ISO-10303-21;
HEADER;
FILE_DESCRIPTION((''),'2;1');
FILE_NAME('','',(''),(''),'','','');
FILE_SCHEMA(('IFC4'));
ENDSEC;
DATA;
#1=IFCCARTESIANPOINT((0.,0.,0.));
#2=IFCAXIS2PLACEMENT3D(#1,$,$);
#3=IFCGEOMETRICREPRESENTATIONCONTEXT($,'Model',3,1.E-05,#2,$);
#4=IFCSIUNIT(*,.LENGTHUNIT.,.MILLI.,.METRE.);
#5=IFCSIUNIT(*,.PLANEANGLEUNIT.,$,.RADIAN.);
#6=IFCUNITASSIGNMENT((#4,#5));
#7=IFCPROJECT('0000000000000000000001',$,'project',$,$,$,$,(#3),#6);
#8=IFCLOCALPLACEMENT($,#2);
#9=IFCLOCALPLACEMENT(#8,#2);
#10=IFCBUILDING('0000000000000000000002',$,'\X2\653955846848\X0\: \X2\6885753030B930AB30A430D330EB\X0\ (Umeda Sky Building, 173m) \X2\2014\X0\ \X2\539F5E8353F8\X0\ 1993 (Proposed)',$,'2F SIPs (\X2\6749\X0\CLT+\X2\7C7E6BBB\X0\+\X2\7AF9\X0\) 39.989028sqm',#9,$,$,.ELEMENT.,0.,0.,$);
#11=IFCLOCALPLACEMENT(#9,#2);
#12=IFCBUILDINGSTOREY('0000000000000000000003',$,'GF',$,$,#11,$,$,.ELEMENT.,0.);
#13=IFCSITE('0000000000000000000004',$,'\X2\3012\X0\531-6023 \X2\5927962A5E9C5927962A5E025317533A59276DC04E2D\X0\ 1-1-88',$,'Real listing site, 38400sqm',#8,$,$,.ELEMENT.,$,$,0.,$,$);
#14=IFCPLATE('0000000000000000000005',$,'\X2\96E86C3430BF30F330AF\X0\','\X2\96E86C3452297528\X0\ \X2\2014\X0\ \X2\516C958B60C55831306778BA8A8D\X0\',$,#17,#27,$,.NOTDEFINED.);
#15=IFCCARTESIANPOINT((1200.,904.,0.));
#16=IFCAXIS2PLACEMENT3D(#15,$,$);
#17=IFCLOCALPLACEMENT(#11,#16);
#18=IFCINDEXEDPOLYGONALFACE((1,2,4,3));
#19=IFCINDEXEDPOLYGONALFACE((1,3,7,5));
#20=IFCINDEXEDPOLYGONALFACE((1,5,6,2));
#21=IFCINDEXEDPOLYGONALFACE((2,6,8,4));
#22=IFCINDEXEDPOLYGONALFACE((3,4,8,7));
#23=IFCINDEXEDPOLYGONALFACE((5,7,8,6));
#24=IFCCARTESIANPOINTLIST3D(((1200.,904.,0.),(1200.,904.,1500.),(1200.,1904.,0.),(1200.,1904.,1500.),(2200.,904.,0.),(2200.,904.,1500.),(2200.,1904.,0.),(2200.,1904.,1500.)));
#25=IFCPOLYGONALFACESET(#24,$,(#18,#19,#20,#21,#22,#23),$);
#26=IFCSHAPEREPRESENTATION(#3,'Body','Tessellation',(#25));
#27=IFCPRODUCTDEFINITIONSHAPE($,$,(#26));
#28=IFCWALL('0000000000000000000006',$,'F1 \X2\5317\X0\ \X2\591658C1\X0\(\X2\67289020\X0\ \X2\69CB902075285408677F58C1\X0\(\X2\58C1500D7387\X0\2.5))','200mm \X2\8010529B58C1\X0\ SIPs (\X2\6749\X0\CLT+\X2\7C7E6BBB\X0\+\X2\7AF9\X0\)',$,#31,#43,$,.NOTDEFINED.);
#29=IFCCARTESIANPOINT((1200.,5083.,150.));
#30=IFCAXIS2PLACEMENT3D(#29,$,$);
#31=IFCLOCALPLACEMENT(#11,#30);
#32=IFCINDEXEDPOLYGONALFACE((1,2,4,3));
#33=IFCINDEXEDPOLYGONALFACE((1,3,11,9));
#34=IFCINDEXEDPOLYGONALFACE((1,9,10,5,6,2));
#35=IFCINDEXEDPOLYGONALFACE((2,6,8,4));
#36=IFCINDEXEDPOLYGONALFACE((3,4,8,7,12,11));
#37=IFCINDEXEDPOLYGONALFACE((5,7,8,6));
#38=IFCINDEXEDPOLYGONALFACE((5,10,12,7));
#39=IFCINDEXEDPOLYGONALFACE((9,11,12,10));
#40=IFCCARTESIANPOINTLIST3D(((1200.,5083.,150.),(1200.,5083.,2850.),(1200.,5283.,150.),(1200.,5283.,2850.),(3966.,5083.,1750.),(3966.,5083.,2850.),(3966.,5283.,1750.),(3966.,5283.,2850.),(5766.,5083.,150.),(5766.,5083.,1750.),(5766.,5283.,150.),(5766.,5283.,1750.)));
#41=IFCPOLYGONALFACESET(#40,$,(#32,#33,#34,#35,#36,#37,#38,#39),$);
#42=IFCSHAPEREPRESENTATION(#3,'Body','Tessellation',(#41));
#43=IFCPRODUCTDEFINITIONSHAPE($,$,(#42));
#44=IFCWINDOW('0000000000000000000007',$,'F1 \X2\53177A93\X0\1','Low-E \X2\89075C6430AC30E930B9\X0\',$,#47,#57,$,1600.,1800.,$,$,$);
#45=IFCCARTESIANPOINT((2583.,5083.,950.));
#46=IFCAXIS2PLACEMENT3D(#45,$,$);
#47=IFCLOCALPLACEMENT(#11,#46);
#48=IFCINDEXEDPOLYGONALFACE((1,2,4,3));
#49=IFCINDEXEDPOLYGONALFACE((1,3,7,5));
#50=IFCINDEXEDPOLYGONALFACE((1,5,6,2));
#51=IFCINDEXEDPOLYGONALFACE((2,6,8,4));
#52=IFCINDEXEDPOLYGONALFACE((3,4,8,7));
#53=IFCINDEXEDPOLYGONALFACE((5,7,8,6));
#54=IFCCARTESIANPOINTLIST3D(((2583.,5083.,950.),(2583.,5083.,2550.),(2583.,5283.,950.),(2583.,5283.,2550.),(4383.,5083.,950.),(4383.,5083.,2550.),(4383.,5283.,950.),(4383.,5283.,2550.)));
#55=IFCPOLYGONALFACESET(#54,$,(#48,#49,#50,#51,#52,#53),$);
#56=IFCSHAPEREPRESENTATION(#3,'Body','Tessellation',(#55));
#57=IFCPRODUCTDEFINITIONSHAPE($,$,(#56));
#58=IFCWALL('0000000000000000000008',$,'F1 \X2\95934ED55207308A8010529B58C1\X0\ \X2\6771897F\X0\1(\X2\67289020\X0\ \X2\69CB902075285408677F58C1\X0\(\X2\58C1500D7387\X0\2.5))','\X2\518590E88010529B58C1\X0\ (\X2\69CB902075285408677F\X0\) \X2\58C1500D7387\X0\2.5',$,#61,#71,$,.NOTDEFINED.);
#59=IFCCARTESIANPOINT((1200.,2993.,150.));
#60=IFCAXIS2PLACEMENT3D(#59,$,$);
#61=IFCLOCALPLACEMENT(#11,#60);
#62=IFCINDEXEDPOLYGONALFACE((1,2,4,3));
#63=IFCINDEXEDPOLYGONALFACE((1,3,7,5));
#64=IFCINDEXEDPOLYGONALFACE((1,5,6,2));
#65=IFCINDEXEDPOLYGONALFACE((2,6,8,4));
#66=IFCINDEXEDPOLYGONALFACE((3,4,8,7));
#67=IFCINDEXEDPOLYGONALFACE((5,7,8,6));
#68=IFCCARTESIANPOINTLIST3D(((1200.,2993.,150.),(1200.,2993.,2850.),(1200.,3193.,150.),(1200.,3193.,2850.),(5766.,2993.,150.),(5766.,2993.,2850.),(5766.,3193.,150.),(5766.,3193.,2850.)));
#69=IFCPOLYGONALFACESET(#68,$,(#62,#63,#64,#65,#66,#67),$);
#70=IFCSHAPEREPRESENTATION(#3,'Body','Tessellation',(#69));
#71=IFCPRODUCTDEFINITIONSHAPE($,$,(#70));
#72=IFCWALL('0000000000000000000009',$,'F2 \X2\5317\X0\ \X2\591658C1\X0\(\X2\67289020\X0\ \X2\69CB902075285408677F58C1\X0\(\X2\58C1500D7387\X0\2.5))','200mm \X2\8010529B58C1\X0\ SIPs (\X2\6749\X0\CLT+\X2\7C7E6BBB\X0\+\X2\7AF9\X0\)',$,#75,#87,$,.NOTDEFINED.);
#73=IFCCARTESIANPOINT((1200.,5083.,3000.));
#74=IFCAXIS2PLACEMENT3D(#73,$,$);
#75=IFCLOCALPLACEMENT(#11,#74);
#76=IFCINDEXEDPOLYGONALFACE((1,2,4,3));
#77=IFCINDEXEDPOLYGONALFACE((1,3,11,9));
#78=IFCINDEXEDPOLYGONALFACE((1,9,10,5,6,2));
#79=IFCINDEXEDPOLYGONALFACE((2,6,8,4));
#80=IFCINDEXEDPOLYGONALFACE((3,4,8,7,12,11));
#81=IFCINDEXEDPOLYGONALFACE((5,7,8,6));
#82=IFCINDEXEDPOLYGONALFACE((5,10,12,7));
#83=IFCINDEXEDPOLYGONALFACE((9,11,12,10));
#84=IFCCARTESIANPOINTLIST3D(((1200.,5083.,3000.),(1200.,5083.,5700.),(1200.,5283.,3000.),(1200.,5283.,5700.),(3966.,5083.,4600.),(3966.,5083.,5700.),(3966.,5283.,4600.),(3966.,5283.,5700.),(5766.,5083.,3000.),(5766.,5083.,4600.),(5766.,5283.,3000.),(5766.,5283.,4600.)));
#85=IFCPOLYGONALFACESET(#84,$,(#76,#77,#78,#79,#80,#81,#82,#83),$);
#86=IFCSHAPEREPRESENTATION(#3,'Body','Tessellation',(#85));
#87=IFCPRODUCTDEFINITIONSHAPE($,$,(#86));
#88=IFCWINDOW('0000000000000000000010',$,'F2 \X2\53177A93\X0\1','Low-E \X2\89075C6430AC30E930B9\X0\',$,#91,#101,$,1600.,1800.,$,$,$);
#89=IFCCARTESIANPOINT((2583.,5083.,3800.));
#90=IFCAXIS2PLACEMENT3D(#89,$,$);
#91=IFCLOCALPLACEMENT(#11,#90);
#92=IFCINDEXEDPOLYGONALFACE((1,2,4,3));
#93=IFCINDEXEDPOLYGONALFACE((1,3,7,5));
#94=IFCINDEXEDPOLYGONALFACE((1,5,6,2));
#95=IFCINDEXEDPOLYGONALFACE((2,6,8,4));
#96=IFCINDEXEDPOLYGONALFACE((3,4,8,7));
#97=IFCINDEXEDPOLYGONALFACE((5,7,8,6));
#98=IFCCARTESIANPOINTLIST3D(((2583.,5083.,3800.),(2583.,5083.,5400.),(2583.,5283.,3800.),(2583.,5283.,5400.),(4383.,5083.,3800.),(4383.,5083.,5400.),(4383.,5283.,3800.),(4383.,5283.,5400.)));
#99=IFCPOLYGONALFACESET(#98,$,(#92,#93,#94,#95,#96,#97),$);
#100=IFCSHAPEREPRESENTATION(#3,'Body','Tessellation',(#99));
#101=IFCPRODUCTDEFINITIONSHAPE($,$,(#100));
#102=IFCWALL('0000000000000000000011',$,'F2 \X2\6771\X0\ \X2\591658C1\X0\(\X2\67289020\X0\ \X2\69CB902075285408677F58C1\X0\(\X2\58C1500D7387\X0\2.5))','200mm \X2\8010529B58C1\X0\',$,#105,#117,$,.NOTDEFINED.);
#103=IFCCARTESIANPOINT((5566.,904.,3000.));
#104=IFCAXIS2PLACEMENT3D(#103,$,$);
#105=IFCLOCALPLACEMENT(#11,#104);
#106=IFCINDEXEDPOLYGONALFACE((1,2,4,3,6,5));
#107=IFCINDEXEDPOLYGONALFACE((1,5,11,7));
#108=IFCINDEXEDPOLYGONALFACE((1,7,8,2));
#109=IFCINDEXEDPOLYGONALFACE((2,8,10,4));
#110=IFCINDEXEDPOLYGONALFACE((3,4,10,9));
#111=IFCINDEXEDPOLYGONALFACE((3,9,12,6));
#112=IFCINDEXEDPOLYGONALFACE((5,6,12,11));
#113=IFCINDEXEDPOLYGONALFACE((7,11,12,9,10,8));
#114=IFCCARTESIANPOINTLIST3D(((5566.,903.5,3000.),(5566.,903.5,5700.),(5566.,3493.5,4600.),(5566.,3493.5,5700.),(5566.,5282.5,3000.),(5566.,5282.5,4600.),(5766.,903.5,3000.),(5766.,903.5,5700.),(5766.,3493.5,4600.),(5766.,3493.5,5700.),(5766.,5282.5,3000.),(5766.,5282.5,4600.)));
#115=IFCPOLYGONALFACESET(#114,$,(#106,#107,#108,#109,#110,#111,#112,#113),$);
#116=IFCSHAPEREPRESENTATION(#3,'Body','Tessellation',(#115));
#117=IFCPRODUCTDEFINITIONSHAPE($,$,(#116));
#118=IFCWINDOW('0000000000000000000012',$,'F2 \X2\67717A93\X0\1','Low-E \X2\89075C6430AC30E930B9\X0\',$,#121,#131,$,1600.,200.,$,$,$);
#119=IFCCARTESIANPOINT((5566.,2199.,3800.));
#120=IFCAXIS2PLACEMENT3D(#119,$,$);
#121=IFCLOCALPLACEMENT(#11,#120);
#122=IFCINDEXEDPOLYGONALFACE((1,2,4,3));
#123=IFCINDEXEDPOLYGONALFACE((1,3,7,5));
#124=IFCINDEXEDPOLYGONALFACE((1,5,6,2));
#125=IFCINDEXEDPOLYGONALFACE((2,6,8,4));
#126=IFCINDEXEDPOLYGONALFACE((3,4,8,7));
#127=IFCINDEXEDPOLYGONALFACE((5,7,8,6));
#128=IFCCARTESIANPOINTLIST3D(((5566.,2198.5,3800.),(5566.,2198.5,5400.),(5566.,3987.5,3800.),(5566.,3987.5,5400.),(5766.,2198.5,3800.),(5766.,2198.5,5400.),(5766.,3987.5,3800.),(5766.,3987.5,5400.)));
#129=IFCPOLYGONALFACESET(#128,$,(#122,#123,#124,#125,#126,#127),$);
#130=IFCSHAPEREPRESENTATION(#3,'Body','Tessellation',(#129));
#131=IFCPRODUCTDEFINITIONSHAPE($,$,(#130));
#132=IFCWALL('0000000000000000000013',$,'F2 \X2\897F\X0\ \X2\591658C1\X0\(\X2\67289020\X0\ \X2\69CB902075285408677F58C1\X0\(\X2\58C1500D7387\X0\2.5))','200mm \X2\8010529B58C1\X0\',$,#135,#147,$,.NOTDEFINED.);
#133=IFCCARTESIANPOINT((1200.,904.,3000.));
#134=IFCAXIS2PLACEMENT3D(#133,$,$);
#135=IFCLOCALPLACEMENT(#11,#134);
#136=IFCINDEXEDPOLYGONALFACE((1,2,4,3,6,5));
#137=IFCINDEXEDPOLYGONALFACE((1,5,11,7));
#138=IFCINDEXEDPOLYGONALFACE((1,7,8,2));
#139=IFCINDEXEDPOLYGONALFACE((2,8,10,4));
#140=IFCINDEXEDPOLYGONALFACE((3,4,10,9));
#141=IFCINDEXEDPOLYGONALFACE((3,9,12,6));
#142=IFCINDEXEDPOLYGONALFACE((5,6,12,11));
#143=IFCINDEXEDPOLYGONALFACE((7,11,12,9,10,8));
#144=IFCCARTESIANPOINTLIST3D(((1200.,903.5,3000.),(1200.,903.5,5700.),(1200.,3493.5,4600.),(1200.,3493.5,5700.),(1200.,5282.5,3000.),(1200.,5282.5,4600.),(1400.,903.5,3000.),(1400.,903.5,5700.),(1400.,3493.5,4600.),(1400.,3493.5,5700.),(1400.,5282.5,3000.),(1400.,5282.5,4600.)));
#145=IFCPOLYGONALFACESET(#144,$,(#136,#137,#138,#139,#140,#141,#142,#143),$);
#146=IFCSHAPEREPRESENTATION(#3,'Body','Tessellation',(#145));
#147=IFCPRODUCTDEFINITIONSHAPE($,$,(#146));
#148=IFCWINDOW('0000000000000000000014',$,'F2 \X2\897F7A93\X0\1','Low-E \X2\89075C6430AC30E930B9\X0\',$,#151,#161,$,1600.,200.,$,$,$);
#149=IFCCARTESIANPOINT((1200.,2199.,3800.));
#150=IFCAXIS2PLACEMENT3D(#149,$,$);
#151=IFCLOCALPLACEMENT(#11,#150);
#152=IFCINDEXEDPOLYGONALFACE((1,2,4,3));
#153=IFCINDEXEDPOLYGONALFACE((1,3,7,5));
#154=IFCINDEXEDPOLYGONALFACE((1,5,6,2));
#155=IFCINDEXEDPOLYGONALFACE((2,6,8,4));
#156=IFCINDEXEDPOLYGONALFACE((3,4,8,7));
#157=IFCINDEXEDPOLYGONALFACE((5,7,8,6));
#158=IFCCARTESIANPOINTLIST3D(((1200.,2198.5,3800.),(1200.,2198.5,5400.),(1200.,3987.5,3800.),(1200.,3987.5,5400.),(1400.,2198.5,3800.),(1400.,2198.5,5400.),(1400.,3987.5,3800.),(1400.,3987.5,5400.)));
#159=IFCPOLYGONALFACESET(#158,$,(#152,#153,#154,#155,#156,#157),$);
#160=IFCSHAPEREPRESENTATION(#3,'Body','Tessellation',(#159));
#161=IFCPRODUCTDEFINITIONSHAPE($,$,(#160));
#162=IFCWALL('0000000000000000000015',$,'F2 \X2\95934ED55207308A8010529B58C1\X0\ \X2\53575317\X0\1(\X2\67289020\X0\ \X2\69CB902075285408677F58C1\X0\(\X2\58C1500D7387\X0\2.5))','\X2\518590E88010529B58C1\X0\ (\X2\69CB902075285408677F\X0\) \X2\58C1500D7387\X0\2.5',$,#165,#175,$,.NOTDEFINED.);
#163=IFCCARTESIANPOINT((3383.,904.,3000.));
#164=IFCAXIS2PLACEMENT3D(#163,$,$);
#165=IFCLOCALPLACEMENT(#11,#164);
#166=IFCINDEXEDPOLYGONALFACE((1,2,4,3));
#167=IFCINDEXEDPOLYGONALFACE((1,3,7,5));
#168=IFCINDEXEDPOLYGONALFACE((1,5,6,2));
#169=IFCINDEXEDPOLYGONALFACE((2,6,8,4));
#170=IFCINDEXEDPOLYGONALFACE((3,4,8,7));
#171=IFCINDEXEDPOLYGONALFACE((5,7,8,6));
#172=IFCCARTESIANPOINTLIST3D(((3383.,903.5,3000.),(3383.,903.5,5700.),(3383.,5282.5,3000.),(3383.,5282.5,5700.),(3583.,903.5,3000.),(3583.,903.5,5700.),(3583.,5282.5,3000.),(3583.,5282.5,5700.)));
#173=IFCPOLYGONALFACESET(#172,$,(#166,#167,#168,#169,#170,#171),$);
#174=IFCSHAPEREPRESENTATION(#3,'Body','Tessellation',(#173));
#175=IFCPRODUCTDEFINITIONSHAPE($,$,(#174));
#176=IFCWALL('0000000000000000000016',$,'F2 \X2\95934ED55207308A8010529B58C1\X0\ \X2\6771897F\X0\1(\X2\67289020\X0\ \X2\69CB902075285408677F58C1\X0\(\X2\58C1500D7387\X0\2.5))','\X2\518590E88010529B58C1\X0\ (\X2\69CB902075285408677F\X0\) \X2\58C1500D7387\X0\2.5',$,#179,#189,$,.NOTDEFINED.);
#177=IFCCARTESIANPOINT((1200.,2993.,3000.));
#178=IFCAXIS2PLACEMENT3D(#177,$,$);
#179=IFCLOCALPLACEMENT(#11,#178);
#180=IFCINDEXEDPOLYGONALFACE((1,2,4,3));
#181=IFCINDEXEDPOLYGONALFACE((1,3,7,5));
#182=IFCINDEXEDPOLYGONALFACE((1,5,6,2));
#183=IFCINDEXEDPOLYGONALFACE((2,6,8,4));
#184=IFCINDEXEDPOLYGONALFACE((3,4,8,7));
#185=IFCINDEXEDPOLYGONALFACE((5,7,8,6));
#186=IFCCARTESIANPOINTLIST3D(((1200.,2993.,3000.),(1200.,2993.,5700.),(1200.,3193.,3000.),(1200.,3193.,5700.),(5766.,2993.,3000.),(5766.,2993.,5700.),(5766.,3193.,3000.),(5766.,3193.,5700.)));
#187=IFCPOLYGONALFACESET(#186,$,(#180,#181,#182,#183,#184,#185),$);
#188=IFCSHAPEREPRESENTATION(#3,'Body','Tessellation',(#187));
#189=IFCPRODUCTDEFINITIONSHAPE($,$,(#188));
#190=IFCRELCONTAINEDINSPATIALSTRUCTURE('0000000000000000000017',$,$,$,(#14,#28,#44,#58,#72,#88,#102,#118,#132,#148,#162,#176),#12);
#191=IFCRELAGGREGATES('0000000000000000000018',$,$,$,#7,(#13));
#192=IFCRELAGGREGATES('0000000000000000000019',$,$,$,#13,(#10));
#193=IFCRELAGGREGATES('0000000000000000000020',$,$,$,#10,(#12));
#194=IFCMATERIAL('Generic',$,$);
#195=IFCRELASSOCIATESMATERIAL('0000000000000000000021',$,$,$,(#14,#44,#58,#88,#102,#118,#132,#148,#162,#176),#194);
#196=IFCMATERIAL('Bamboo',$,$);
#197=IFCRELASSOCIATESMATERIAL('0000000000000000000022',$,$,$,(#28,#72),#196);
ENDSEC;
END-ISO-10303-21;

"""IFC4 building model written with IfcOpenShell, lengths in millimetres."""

from ifc_helpers import new_model, si_unit, frame, frame_2d, origin, place, context, project, spatial, rectangle, extrude, material, element, fill, save


model = new_model("IFC4")

# Units and contexts
model_context = context("Model", 3, precision=1e-05, world=origin())
ifc_project = project(units=[si_unit("LENGTHUNIT", "METRE", prefix="MILLI"), si_unit("PLANEANGLEUNIT", "RADIAN")], contexts=[model_context])

# Site, building, storey
site_placement = place(None, origin())
site = spatial("IfcSite", under=ifc_project, at=site_placement, Name="〒531-6023 大阪府大阪市北区大淀中 1-1-88", ObjectType="Real listing site, 38400sqm", CompositionType="ELEMENT", RefElevation=0.0)
building_placement = place(site_placement, origin())
building = spatial("IfcBuilding", under=site, at=building_placement, Name="改善案: 梅田スカイビル (Umeda Sky Building, 173m) — 原広司 1993 (Proposed)", ObjectType="2F SIPs (杉CLT+籾殻+竹) 39.989028sqm", CompositionType="ELEMENT", ElevationOfRefHeight=0.0, ElevationOfTerrain=0.0)
storey_placement = place(building_placement, origin())
storey = spatial("IfcBuildingStorey", under=building, at=storey_placement, Name="GF", CompositionType="ELEMENT", Elevation=0.0)

# Plate
ifc_material_1 = material(Name="Generic")
plate_placement = place(storey_placement, frame((1200.0, 904.0, 0.0)))
element("IfcPlate", 1, at=plate_placement, inside=storey, material=ifc_material_1, Name="雨水タンク", Description="雨水利用 — 公開情報で確認", PredefinedType="NOTDEFINED", context=model_context, shape_type="SweptSolid", body=[
    extrude(rectangle(XDim=1000.0, YDim=1000.0, at=frame_2d((500.0, 500.0))), frame((1200.0, 904.0, 0.0)), (0.0, 0.0, 1.0), 1500.0),
])

# Wall, opening, window
ifc_material_2 = material(Name="Bamboo")
wall_1_placement = place(storey_placement, frame((1200.0, 5083.0, 150.0)))
wall_1 = element("IfcWall", 2, at=wall_1_placement, inside=storey, material=ifc_material_2, Name="F1 北 外壁(木造 構造用合板壁(壁倍率2.5))", Description="200mm 耐力壁 SIPs (杉CLT+籾殻+竹)", PredefinedType="NOTDEFINED", context=model_context, shape_type="SweptSolid", body=[
    extrude(rectangle(XDim=4566.0, YDim=200.0, at=frame_2d((2283.0, 100.0))), frame((1200.0, 5083.0, 150.0)), (0.0, 0.0, 1.0), 2700.0),
])
opening_1_placement = place(storey_placement, frame((2583.0, 5083.0, 950.0)))
opening_1 = element("IfcOpeningElement", 3, at=opening_1_placement, cuts=wall_1, PredefinedType="NOTDEFINED", context=model_context, shape_type="SweptSolid", body=[
    extrude(rectangle(XDim=1800.0, YDim=200.0, at=frame_2d((900.0, 100.0))), frame((2583.0, 5083.0, 950.0)), (0.0, 0.0, 1.0), 1600.0),
])
window_1_placement = place(storey_placement, frame((2583.0, 5083.0, 950.0)))
window_1 = element("IfcWindow", 4, at=window_1_placement, inside=storey, material=ifc_material_1, Name="F1 北窓1", Description="Low-E 複層ガラス", OverallHeight=1600.0, OverallWidth=1800.0, context=model_context, shape_type="SweptSolid", body=[
    extrude(rectangle(XDim=1800.0, YDim=200.0, at=frame_2d((900.0, 100.0))), frame((2583.0, 5083.0, 950.0)), (0.0, 0.0, 1.0), 1600.0),
])
fill(opening_1, window_1)

# Wall
wall_2_placement = place(storey_placement, frame((1200.0, 2993.0, 150.0)))
element("IfcWall", 5, at=wall_2_placement, inside=storey, material=ifc_material_1, Name="F1 間仕切り耐力壁 東西1(木造 構造用合板壁(壁倍率2.5))", Description="内部耐力壁 (構造用合板) 壁倍率2.5", PredefinedType="NOTDEFINED", context=model_context, shape_type="SweptSolid", body=[
    extrude(rectangle(XDim=4566.0, YDim=200.0, at=frame_2d((2283.0, 100.0))), frame((1200.0, 2993.0, 150.0)), (0.0, 0.0, 1.0), 2700.0),
])

# Walls, openings, windows
wall_3_placement = place(storey_placement, frame((1200.0, 5083.0, 3000.0)))
wall_3 = element("IfcWall", 6, at=wall_3_placement, inside=storey, material=ifc_material_2, Name="F2 北 外壁(木造 構造用合板壁(壁倍率2.5))", Description="200mm 耐力壁 SIPs (杉CLT+籾殻+竹)", PredefinedType="NOTDEFINED", context=model_context, shape_type="SweptSolid", body=[
    extrude(rectangle(XDim=4566.0, YDim=200.0, at=frame_2d((2283.0, 100.0))), frame((1200.0, 5083.0, 3000.0)), (0.0, 0.0, 1.0), 2700.0),
])
opening_2_placement = place(storey_placement, frame((2583.0, 5083.0, 3800.0)))
opening_2 = element("IfcOpeningElement", 7, at=opening_2_placement, cuts=wall_3, PredefinedType="NOTDEFINED", context=model_context, shape_type="SweptSolid", body=[
    extrude(rectangle(XDim=1800.0, YDim=200.0, at=frame_2d((900.0, 100.0))), frame((2583.0, 5083.0, 3800.0)), (0.0, 0.0, 1.0), 1600.0),
])
window_2_placement = place(storey_placement, frame((2583.0, 5083.0, 3800.0)))
window_2 = element("IfcWindow", 8, at=window_2_placement, inside=storey, material=ifc_material_1, Name="F2 北窓1", Description="Low-E 複層ガラス", OverallHeight=1600.0, OverallWidth=1800.0, context=model_context, shape_type="SweptSolid", body=[
    extrude(rectangle(XDim=1800.0, YDim=200.0, at=frame_2d((900.0, 100.0))), frame((2583.0, 5083.0, 3800.0)), (0.0, 0.0, 1.0), 1600.0),
])
fill(opening_2, window_2)
wall_4_placement = place(storey_placement, frame((5566.0, 904.0, 3000.0)))
wall_4 = element("IfcWall", 9, at=wall_4_placement, inside=storey, material=ifc_material_1, Name="F2 東 外壁(木造 構造用合板壁(壁倍率2.5))", Description="200mm 耐力壁", PredefinedType="NOTDEFINED", context=model_context, shape_type="SweptSolid", body=[
    extrude(rectangle(XDim=200.0, YDim=4379.0, at=frame_2d((100.0, 2189.0))), frame((5566.0, 904.0, 3000.0)), (0.0, 0.0, 1.0), 2700.0),
])
opening_3_placement = place(storey_placement, frame((5566.0, 2199.0, 3800.0)))
opening_3 = element("IfcOpeningElement", 10, at=opening_3_placement, cuts=wall_4, PredefinedType="NOTDEFINED", context=model_context, shape_type="SweptSolid", body=[
    extrude(rectangle(XDim=200.0, YDim=1789.0, at=frame_2d((100.0, 894.0))), frame((5566.0, 2199.0, 3800.0)), (0.0, 0.0, 1.0), 1600.0),
])
window_3_placement = place(storey_placement, frame((5566.0, 2199.0, 3800.0)))
window_3 = element("IfcWindow", 11, at=window_3_placement, inside=storey, material=ifc_material_1, Name="F2 東窓1", Description="Low-E 複層ガラス", OverallHeight=1600.0, OverallWidth=200.0, context=model_context, shape_type="SweptSolid", body=[
    extrude(rectangle(XDim=200.0, YDim=1789.0, at=frame_2d((100.0, 894.0))), frame((5566.0, 2199.0, 3800.0)), (0.0, 0.0, 1.0), 1600.0),
])
fill(opening_3, window_3)
wall_5_placement = place(storey_placement, frame((1200.0, 904.0, 3000.0)))
wall_5 = element("IfcWall", 12, at=wall_5_placement, inside=storey, material=ifc_material_1, Name="F2 西 外壁(木造 構造用合板壁(壁倍率2.5))", Description="200mm 耐力壁", PredefinedType="NOTDEFINED", context=model_context, shape_type="SweptSolid", body=[
    extrude(rectangle(XDim=200.0, YDim=4379.0, at=frame_2d((100.0, 2189.0))), frame((1200.0, 904.0, 3000.0)), (0.0, 0.0, 1.0), 2700.0),
])
opening_4_placement = place(storey_placement, frame((1200.0, 2199.0, 3800.0)))
opening_4 = element("IfcOpeningElement", 13, at=opening_4_placement, cuts=wall_5, PredefinedType="NOTDEFINED", context=model_context, shape_type="SweptSolid", body=[
    extrude(rectangle(XDim=200.0, YDim=1789.0, at=frame_2d((100.0, 894.0))), frame((1200.0, 2199.0, 3800.0)), (0.0, 0.0, 1.0), 1600.0),
])
window_4_placement = place(storey_placement, frame((1200.0, 2199.0, 3800.0)))
window_4 = element("IfcWindow", 14, at=window_4_placement, inside=storey, material=ifc_material_1, Name="F2 西窓1", Description="Low-E 複層ガラス", OverallHeight=1600.0, OverallWidth=200.0, context=model_context, shape_type="SweptSolid", body=[
    extrude(rectangle(XDim=200.0, YDim=1789.0, at=frame_2d((100.0, 894.0))), frame((1200.0, 2199.0, 3800.0)), (0.0, 0.0, 1.0), 1600.0),
])
fill(opening_4, window_4)

# Walls
wall_6_placement = place(storey_placement, frame((3383.0, 904.0, 3000.0)))
element("IfcWall", 15, at=wall_6_placement, inside=storey, material=ifc_material_1, Name="F2 間仕切り耐力壁 南北1(木造 構造用合板壁(壁倍率2.5))", Description="内部耐力壁 (構造用合板) 壁倍率2.5", PredefinedType="NOTDEFINED", context=model_context, shape_type="SweptSolid", body=[
    extrude(rectangle(XDim=200.0, YDim=4379.0, at=frame_2d((100.0, 2189.0))), frame((3383.0, 904.0, 3000.0)), (0.0, 0.0, 1.0), 2700.0),
])
wall_7_placement = place(storey_placement, frame((1200.0, 2993.0, 3000.0)))
element("IfcWall", 16, at=wall_7_placement, inside=storey, material=ifc_material_1, Name="F2 間仕切り耐力壁 東西1(木造 構造用合板壁(壁倍率2.5))", Description="内部耐力壁 (構造用合板) 壁倍率2.5", PredefinedType="NOTDEFINED", context=model_context, shape_type="SweptSolid", body=[
    extrude(rectangle(XDim=4566.0, YDim=200.0, at=frame_2d((2283.0, 100.0))), frame((1200.0, 2993.0, 3000.0)), (0.0, 0.0, 1.0), 2700.0),
])

save(model, "model.ifc")
